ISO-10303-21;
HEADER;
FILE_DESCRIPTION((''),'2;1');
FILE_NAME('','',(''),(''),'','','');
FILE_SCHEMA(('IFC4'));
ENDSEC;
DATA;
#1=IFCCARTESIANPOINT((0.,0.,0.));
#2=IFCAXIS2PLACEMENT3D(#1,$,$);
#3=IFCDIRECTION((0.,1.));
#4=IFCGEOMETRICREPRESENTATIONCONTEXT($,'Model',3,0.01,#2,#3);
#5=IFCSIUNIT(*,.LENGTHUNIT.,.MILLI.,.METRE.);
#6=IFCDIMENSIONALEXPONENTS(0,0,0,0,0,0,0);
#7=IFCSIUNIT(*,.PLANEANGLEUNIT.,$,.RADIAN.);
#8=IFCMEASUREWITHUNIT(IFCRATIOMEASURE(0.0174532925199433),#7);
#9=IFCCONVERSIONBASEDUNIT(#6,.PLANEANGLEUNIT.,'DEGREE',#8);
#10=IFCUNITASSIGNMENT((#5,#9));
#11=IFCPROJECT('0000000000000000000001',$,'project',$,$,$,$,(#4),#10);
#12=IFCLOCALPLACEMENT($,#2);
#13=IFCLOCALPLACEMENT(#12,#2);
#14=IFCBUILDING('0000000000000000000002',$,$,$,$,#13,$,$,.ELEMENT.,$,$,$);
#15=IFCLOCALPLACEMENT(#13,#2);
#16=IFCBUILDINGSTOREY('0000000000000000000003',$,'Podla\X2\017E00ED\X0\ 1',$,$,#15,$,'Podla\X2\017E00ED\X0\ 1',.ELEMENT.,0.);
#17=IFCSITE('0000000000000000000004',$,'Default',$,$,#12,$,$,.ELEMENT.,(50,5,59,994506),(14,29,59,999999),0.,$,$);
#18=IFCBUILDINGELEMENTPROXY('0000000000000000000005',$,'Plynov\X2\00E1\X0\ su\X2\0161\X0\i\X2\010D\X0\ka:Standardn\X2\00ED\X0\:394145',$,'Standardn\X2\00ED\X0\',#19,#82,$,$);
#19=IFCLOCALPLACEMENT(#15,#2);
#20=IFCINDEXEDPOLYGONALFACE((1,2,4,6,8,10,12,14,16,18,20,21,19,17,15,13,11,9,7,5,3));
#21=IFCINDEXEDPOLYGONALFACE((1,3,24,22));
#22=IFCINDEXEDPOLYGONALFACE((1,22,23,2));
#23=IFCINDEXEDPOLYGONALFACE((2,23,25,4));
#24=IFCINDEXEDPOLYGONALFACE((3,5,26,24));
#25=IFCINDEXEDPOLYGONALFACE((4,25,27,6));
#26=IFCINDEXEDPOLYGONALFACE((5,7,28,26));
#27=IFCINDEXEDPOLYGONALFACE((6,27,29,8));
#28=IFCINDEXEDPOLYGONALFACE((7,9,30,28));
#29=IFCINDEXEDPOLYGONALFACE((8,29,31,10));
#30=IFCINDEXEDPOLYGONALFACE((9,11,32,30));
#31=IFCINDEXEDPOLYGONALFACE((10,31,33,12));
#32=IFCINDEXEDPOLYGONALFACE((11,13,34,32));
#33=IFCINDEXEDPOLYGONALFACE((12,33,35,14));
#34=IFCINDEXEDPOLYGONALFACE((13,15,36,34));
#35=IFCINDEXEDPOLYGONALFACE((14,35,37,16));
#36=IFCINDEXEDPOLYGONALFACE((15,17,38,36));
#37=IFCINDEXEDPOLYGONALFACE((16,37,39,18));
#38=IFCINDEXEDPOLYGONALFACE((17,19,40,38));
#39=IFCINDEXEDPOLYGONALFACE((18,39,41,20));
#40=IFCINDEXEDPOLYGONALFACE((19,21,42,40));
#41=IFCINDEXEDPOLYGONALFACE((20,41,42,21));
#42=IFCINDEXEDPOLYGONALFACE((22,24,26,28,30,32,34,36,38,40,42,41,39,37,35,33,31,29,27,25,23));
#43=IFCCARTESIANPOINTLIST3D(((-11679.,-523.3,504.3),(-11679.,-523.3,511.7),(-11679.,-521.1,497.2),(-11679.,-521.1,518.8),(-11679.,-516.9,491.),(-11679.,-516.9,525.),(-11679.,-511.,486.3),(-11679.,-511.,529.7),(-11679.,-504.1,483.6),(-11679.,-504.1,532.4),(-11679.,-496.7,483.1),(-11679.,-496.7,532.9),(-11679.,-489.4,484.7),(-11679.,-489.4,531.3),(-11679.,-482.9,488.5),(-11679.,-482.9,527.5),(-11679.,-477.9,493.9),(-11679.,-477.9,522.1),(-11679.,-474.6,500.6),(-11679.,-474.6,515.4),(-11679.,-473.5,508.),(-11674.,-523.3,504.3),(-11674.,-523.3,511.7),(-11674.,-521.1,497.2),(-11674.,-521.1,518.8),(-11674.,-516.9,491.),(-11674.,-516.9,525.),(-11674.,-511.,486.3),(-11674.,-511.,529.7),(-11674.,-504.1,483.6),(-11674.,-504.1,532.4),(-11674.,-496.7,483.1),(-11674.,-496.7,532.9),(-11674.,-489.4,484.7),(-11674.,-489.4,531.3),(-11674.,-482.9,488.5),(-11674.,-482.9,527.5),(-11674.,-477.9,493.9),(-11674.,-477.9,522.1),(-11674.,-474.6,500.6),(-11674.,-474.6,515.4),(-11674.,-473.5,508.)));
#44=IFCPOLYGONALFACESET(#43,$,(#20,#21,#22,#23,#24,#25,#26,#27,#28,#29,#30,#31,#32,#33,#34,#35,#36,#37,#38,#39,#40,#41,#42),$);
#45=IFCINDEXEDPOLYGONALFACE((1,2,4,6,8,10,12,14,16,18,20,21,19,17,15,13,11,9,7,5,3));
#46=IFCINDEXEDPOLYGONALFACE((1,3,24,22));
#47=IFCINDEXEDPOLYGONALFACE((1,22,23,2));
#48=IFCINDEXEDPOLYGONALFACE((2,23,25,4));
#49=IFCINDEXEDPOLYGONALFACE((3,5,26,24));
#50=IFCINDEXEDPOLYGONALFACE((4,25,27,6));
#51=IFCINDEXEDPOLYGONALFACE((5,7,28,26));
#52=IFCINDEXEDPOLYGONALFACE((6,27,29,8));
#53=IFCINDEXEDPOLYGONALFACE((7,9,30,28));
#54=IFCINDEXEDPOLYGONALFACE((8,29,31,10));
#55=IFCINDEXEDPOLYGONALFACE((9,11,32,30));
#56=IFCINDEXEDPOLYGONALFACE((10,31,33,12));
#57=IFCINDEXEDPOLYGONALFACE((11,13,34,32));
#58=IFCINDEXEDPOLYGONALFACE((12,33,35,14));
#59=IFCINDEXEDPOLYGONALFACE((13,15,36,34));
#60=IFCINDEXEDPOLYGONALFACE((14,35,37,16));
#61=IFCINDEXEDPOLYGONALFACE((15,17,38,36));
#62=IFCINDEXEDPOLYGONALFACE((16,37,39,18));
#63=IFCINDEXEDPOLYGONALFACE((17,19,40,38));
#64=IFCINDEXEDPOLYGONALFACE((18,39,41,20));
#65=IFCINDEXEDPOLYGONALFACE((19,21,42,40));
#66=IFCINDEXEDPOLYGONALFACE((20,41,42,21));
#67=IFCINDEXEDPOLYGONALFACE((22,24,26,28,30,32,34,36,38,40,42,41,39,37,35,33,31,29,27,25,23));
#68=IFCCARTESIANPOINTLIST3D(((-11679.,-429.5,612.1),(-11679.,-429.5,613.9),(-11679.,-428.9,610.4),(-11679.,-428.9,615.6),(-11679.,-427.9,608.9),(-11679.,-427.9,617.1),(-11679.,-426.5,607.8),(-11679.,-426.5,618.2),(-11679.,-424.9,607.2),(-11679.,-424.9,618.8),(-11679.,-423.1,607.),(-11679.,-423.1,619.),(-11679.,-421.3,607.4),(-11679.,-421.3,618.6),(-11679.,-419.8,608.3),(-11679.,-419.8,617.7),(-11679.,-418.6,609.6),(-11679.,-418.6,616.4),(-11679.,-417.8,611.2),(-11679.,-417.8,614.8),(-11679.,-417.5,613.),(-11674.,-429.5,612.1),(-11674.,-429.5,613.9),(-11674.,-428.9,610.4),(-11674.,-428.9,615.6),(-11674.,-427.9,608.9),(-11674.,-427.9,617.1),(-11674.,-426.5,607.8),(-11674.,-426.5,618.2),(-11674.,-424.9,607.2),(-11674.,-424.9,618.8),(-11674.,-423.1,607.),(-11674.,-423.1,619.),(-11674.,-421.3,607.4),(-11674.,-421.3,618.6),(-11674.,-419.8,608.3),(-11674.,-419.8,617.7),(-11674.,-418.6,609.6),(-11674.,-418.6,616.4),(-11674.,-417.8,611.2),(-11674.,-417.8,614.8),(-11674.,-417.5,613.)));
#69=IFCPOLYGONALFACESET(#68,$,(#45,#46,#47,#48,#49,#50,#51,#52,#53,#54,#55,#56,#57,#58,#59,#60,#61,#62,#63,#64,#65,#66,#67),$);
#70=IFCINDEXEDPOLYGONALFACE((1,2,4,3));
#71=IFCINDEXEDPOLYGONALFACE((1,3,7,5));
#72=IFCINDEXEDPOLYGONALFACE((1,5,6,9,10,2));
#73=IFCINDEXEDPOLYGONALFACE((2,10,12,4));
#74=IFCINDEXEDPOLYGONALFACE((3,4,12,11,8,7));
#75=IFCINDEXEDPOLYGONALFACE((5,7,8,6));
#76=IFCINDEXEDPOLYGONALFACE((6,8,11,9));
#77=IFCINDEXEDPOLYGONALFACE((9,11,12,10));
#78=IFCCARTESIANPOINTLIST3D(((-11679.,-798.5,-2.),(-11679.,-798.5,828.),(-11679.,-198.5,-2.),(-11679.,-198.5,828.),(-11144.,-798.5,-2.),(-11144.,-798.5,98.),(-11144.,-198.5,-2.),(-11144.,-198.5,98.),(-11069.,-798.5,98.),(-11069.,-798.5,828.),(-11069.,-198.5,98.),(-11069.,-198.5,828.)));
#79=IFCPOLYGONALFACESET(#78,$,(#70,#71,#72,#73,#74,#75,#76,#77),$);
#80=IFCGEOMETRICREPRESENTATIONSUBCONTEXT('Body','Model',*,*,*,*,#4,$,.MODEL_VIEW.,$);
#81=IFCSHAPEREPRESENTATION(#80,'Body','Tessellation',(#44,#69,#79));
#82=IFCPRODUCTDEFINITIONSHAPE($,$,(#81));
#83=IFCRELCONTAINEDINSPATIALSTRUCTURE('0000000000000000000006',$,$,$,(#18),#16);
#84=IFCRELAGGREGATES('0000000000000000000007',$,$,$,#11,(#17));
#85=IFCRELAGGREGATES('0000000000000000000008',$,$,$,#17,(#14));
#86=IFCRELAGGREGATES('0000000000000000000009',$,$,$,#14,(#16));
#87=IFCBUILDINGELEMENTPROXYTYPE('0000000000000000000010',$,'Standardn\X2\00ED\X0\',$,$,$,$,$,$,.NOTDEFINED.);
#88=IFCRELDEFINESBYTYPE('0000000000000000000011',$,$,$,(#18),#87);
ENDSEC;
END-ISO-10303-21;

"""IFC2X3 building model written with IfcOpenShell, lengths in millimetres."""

from ifc_helpers import new_model, entity, si_unit, converted_unit, direction, frame, frame_2d, origin, origin_2d_with_axis, place, context, subcontext, project, spatial, polyline, circle, outline, extrude, source, transform, mapped, type_object, type_shapes, element, save


model = new_model("IFC2X3")

# Units and contexts
model_context = context("Model", 3, precision=0.01, world=origin(), true_north=direction((0.0, 1.0)))
body_context = subcontext(model_context, "Body", "Model", "MODEL_VIEW")
ifc_project = project(units=[si_unit("LENGTHUNIT", "METRE", prefix="MILLI"), converted_unit("PLANEANGLEUNIT", "DEGREE", entity("IfcRatioMeasure", 0.0174532925199433), si_unit("PLANEANGLEUNIT", "RADIAN"), dimensions=[0, 0, 0, 0, 0, 0, 0])], contexts=[model_context])

# Site, building, storey
site_placement = place(None, origin())
site = spatial("IfcSite", under=ifc_project, at=site_placement, Name="Default", CompositionType="ELEMENT", RefLatitude=(50, 5, 59, 994506), RefLongitude=(14, 29, 59, 999999), RefElevation=0.0)
building_placement = place(site_placement, origin())
building = spatial("IfcBuilding", under=site, at=building_placement, CompositionType="ELEMENT")
storey_placement = place(building_placement, origin())
storey = spatial("IfcBuildingStorey", under=building, at=storey_placement, Name="Podlaží 1", LongName="Podlaží 1", CompositionType="ELEMENT", Elevation=0.0)

# Building element proxy
building_element_proxy_type_1 = type_object("IfcBuildingElementProxyType", Name="Standardní", PredefinedType="NOTDEFINED")
shared_shape_1 = source(origin(), body_context, "Body", "SweptSolid", [
    extrude(circle(Radius=25.0, at=frame_2d((0.0, 0.0), x_axis=(1.0, 0.0))), frame((0.0, 0.0, 510.0), z_axis=(1.0, 0.0, 0.0), x_axis=(0.0, 1.0, 0.0)), (0.0, 0.0, 1.0), 5.0),
    extrude(circle(Radius=6.0, at=origin_2d_with_axis()), frame((0.0, 75.0, 615.0), z_axis=(1.0, 0.0, 0.0), x_axis=(0.0, 1.0, 0.0)), (0.0, 0.0, 1.0), 5.0),
    extrude(outline(polyline([(-153.3, -310.0), (381.7, -310.0), (381.7, 520.0), (-228.3, 520.0), (-228.3, -210.0), (-153.3, -210.0), (-153.3, -310.0)])), frame((381.7, -300.0, 310.0), z_axis=(0.0, 1.0, 0.0), x_axis=(-1.0, 0.0, 0.0)), (0.0, 0.0, 1.0), 600.0),
])
type_shapes(building_element_proxy_type_1, [shared_shape_1])
proxy_1_placement = place(storey_placement, frame((-11679.0, -498.5, -2.0)))
element("IfcBuildingElementProxy", 1, at=proxy_1_placement, inside=storey, type_object=building_element_proxy_type_1, Name="Plynová sušička:Standardní:394145", ObjectType="Standardní", context=body_context, shape_type="MappedRepresentation", body=[
    mapped(shared_shape_1, transform((0.0, 0.0, 0.0), scale=1.0)),
])

save(model, "model.ifc")
